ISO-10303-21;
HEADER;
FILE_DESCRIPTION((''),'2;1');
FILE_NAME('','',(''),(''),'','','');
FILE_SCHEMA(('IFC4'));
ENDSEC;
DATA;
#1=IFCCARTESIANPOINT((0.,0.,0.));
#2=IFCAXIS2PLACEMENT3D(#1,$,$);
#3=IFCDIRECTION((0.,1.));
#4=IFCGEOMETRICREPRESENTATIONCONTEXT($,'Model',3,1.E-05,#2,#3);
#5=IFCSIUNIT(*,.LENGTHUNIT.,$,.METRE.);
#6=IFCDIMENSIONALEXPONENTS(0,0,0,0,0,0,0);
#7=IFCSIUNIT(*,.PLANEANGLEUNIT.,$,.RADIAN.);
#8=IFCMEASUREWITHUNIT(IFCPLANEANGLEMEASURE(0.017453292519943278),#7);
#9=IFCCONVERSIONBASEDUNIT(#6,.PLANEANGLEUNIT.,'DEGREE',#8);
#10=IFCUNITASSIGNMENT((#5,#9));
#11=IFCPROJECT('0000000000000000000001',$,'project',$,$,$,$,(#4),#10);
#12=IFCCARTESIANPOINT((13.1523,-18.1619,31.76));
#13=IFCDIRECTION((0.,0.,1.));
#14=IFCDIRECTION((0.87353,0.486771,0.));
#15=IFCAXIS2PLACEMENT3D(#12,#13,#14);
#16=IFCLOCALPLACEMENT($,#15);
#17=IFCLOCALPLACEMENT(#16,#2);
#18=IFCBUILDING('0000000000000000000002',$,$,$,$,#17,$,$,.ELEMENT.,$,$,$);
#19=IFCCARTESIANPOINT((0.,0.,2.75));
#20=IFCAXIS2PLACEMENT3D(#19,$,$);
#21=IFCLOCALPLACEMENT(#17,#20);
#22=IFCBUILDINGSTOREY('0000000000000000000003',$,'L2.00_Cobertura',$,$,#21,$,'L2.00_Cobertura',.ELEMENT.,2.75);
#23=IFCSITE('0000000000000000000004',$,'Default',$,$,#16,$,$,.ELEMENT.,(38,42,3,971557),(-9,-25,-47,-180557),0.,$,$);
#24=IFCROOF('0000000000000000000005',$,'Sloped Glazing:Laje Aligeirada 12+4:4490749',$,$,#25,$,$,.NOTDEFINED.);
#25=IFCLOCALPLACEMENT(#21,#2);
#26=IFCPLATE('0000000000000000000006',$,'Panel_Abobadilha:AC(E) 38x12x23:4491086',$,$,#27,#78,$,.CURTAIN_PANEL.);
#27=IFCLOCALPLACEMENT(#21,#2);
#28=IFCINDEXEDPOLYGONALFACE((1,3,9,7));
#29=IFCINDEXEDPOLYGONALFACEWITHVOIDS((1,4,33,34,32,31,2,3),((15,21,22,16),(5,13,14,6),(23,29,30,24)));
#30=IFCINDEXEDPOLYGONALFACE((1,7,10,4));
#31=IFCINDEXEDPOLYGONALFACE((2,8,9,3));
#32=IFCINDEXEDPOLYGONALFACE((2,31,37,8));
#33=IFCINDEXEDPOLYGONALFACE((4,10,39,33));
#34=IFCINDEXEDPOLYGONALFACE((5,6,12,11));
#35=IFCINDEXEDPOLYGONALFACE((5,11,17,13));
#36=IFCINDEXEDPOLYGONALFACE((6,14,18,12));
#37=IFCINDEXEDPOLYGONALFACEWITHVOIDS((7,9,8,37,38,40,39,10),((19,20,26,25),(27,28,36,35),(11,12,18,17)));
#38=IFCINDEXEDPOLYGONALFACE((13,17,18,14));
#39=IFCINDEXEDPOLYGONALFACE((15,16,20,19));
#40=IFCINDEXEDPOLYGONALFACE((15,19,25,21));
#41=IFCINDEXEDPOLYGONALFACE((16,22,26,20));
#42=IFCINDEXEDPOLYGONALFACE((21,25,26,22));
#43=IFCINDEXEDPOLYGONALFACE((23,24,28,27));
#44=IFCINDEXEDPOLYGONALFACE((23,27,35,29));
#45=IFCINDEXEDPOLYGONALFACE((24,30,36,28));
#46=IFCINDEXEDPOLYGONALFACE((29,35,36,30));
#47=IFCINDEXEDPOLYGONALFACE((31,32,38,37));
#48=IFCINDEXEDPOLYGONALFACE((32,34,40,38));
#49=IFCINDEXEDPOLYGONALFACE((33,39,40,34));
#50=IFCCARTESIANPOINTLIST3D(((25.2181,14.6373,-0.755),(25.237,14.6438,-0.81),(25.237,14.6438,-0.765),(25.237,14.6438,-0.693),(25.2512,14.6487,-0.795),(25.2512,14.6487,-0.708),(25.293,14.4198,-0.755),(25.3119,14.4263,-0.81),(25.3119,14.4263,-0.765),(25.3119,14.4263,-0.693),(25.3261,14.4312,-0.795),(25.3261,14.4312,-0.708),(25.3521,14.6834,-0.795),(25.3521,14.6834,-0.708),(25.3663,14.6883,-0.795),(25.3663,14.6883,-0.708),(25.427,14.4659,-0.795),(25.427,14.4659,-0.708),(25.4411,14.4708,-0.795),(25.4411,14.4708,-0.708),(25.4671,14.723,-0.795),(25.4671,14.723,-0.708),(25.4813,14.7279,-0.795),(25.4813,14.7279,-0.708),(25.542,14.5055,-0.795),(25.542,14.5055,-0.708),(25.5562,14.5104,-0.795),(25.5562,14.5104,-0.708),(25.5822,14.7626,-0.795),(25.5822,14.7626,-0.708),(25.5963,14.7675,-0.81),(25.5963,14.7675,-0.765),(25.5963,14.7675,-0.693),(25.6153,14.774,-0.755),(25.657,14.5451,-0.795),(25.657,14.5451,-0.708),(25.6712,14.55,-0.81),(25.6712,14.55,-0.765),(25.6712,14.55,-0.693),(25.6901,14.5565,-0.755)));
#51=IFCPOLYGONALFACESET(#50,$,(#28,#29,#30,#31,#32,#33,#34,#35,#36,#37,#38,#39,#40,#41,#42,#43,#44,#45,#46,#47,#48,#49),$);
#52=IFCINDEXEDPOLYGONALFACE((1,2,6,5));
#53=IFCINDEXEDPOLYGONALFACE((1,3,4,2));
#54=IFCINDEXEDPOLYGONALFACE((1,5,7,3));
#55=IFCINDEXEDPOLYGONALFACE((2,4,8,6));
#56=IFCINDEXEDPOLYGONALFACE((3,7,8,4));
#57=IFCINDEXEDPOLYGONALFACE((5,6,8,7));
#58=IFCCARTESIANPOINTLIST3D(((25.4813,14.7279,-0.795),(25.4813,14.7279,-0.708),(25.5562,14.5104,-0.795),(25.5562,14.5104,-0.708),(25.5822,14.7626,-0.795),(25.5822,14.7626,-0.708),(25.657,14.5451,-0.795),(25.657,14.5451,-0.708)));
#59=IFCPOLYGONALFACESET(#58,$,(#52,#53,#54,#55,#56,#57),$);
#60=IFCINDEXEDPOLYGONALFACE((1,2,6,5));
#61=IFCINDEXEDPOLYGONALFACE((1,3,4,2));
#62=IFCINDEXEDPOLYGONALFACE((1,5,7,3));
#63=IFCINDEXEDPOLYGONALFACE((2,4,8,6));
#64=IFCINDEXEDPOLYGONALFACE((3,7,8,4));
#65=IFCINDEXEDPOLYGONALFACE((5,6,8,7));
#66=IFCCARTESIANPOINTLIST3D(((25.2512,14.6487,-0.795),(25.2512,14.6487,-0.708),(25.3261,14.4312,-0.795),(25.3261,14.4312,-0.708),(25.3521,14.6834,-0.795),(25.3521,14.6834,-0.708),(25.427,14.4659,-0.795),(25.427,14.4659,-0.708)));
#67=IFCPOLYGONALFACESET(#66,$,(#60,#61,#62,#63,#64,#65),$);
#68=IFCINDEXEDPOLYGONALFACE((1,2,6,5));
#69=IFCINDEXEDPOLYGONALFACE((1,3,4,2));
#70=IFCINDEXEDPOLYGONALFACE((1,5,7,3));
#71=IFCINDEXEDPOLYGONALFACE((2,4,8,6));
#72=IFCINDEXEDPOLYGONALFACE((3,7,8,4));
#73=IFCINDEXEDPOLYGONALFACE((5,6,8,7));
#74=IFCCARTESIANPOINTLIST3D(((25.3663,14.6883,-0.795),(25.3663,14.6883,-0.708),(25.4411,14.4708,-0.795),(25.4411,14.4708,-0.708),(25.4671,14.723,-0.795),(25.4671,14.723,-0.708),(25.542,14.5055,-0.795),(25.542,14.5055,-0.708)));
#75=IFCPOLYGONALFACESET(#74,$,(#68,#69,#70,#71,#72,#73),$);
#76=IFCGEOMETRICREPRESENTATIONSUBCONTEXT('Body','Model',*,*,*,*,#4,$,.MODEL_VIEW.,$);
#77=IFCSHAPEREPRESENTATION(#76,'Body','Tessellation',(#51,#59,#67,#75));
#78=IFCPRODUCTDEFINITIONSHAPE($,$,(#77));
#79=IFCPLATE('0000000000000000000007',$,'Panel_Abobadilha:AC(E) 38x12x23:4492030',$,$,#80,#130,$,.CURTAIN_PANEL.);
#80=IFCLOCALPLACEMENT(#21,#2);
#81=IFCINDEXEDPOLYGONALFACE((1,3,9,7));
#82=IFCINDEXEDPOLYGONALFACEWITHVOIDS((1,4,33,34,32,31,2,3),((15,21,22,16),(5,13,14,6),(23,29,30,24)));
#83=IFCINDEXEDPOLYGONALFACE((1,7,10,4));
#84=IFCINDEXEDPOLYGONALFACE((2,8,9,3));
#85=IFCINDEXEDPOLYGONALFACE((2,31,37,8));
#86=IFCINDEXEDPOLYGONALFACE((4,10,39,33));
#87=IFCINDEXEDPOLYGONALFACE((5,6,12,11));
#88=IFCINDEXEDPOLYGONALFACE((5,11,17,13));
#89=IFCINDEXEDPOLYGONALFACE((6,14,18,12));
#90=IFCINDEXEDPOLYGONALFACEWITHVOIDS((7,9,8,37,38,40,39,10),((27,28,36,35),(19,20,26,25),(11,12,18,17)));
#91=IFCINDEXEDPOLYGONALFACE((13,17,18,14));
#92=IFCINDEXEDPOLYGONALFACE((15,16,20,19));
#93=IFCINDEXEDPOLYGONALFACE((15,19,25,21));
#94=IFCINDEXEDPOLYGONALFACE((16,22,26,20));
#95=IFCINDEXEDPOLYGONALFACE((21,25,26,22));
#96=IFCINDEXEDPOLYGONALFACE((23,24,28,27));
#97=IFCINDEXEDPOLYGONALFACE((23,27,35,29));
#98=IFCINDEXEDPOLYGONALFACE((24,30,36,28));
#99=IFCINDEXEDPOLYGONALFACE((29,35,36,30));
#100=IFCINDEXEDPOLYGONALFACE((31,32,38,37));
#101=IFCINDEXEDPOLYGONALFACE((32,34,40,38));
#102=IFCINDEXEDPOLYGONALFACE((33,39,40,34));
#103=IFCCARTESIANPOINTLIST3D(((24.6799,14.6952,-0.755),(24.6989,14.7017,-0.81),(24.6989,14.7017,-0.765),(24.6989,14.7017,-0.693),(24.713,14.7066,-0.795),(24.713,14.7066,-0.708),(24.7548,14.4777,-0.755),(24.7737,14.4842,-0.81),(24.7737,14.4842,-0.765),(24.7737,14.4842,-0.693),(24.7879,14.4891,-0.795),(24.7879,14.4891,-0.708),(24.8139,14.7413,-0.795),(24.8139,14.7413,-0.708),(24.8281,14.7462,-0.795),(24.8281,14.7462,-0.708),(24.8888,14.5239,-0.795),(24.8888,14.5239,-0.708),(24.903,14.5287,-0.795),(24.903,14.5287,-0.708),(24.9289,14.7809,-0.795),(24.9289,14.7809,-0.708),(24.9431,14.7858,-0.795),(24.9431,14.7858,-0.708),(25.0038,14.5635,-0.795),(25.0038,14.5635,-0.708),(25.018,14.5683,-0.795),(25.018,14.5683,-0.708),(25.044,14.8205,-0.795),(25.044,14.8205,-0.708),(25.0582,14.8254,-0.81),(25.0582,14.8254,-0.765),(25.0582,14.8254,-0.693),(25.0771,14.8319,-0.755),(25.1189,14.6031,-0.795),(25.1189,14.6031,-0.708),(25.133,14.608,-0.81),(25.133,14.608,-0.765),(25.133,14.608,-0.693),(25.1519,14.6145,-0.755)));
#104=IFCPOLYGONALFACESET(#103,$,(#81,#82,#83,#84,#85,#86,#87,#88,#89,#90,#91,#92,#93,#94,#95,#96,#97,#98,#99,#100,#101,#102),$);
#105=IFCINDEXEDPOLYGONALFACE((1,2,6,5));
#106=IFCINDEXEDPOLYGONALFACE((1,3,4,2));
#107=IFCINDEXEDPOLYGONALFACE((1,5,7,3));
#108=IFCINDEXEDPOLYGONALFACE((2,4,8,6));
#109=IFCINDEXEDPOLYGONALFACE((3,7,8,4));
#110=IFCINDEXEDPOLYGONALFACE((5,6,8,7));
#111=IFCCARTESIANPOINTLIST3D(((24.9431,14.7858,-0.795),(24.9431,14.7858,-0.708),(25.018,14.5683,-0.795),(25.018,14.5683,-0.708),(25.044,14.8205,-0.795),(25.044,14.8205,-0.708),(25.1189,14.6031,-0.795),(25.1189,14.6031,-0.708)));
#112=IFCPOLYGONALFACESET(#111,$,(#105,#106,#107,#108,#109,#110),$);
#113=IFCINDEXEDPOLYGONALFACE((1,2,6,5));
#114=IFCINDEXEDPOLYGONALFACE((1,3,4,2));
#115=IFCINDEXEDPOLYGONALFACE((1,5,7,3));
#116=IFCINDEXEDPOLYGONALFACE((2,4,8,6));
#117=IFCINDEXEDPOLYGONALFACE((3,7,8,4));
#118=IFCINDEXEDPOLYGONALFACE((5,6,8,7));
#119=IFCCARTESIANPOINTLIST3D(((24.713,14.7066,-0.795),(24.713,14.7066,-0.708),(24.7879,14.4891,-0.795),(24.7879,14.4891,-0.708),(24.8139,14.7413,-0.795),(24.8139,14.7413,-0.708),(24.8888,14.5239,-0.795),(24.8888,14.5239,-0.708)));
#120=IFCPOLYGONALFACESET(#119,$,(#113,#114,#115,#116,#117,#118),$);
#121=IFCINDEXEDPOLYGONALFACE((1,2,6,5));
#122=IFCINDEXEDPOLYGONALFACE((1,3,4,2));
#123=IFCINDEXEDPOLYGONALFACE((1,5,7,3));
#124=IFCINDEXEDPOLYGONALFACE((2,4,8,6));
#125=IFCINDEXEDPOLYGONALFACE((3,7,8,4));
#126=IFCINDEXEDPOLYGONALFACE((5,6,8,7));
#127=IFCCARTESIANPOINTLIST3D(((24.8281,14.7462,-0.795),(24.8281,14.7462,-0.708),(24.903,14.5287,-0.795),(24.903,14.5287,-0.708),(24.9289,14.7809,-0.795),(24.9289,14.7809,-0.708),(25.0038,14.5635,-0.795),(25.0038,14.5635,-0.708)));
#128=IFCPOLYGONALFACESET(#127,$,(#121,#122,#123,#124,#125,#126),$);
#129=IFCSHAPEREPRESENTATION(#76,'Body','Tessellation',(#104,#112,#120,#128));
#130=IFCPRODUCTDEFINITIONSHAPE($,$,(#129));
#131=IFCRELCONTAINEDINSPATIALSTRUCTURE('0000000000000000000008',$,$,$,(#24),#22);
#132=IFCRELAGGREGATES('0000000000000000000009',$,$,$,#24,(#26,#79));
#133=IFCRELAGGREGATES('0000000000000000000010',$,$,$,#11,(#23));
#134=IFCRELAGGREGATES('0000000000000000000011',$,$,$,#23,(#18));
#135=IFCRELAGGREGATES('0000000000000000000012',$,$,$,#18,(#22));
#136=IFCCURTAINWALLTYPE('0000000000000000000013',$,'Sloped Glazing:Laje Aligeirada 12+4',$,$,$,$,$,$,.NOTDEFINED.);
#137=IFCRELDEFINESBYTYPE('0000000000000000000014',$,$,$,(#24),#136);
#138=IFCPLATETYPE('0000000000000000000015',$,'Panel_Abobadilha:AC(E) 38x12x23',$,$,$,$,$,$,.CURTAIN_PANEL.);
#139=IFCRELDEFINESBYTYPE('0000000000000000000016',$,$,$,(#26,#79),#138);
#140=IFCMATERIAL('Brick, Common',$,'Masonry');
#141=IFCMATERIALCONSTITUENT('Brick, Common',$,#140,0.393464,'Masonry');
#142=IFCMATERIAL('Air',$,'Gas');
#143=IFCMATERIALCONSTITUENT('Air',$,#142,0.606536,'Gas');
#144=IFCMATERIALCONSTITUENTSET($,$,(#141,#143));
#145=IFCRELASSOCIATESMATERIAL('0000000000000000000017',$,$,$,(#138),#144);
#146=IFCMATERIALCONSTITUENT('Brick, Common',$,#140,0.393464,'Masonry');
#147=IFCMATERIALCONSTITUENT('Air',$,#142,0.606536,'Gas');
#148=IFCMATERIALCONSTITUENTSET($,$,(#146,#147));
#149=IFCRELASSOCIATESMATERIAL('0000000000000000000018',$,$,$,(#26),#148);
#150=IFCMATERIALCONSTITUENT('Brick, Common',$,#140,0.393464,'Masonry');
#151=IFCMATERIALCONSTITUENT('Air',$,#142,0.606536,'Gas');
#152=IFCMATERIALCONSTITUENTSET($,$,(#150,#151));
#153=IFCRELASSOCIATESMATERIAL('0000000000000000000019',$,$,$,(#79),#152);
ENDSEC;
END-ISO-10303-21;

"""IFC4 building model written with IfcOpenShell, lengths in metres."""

from ifc_helpers import new_model, entity, si_unit, converted_unit, direction, frame, origin, place, context, subcontext, project, spatial, indexed_curve, outline, extrude, source, transform, mapped, material, constituent, constituent_set, type_object, type_shapes, element, aggregate, save


model = new_model("IFC4")

# Units and contexts
model_context = context("Model", 3, precision=1e-05, world=origin(), true_north=direction((0.0, 1.0)))
body_context = subcontext(model_context, "Body", "Model", "MODEL_VIEW")
ifc_project = project(units=[si_unit("LENGTHUNIT", "METRE"), converted_unit("PLANEANGLEUNIT", "DEGREE", entity("IfcPlaneAngleMeasure", 0.017453292519943278), si_unit("PLANEANGLEUNIT", "RADIAN"), dimensions=[0, 0, 0, 0, 0, 0, 0])], contexts=[model_context])

# Site, building, storey
site_placement = place(None, frame((13.1523, -18.1619, 31.76), z_axis=(0.0, 0.0, 1.0), x_axis=(0.87353, 0.486771, 0.0)))
site = spatial("IfcSite", under=ifc_project, at=site_placement, Name="Default", CompositionType="ELEMENT", RefLatitude=(38, 42, 3, 971557), RefLongitude=(-9, -25, -47, -180557), RefElevation=0.0)
building_placement = place(site_placement, origin())
building = spatial("IfcBuilding", under=site, at=building_placement, CompositionType="ELEMENT")
storey_placement = place(building_placement, frame((0.0, 0.0, 2.75)))
storey = spatial("IfcBuildingStorey", under=building, at=storey_placement, Name="L2.00_Cobertura", LongName="L2.00_Cobertura", CompositionType="ELEMENT", Elevation=2.75)

# Roof, plates
curtain_wall_type = type_object("IfcCurtainWallType", Name="Sloped Glazing:Laje Aligeirada 12+4", PredefinedType="NOTDEFINED")
roof_placement = place(storey_placement, frame((0.0, 0.0, -2.75)))
roof = element("IfcRoof", 1, at=roof_placement, inside=storey, type_object=curtain_wall_type, Name="Sloped Glazing:Laje Aligeirada 12+4:4490749", PredefinedType="NOTDEFINED")
ifc_material_1 = material(Name="Brick, Common", Category="Masonry")
ifc_material_2 = material(Name="Air", Category="Gas")
ifc_constituent_1 = constituent(ifc_material_1, Name="Brick, Common", Category="Masonry", fraction=0.393464)
ifc_constituent_2 = constituent(ifc_material_2, Name="Air", Category="Gas", fraction=0.606536)
ifc_constituent_set_1 = constituent_set(constituents=[ifc_constituent_1, ifc_constituent_2])
plate_type = type_object("IfcPlateType", Name="Panel_Abobadilha:AC(E) 38x12x23", PredefinedType="CURTAIN_PANEL", material=ifc_constituent_set_1)
shared_shape_1 = source(origin(), body_context, "Body", "SweptSolid", [
    extrude(outline(indexed_curve([(-0.19, -0.0543), (0.19, -0.0543), (0.19, -0.0093), (0.21, 0.0007), (0.19, 0.0628), (-0.19, 0.0628), (-0.21, 0.0007), (-0.19, -0.0093), (-0.19, -0.0543)], self_intersect=False), holes=[indexed_curve([(-0.0683, 0.0477), (-0.0683, -0.0393), (-0.175, -0.0393), (-0.175, 0.0477), (-0.0683, 0.0477)], self_intersect=False), indexed_curve([(0.0533, 0.0477), (0.0533, -0.0393), (-0.0533, -0.0393), (-0.0533, 0.0477), (0.0533, 0.0477)], self_intersect=False), indexed_curve([(0.175, 0.0477), (0.175, -0.0393), (0.0683, -0.0393), (0.0683, 0.0477), (0.175, 0.0477)], self_intersect=False)]), frame((0.0, 0.0543, 0.0)), (0.0, 0.0, 1.0), 0.23),
    extrude(outline(indexed_curve([(-0.0533, -0.0435), (0.0533, -0.0435), (0.0533, 0.0435), (-0.0533, 0.0435), (-0.0533, -0.0435)], self_intersect=False)), frame((0.1217, 0.0585, 0.0), z_axis=(0.0, 0.0, 1.0), x_axis=(-1.0, 0.0, 0.0)), (0.0, 0.0, 1.0), 0.23),
    extrude(outline(indexed_curve([(-0.0533, -0.0435), (0.0533, -0.0435), (0.0533, 0.0435), (-0.0533, 0.0435), (-0.0533, -0.0435)], self_intersect=False)), frame((-0.1217, 0.0585, 0.0), z_axis=(0.0, 0.0, 1.0), x_axis=(-1.0, 0.0, 0.0)), (0.0, 0.0, 1.0), 0.23),
    extrude(outline(indexed_curve([(-0.0533, -0.0435), (0.0533, -0.0435), (0.0533, 0.0435), (-0.0533, 0.0435), (-0.0533, -0.0435)], self_intersect=False)), frame((0.0, 0.0585, 0.0), z_axis=(0.0, 0.0, 1.0), x_axis=(-1.0, 0.0, 0.0)), (0.0, 0.0, 1.0), 0.23),
])
type_shapes(plate_type, [shared_shape_1])
ifc_constituent_3 = constituent(ifc_material_1, Name="Brick, Common", Category="Masonry", fraction=0.393464)
ifc_constituent_4 = constituent(ifc_material_2, Name="Air", Category="Gas", fraction=0.606536)
ifc_constituent_set_2 = constituent_set(constituents=[ifc_constituent_3, ifc_constituent_4])
plate_1_placement = place(roof_placement, frame((25.4167, 14.7056, 1.94), z_axis=(0.325568, -0.945519, 0.0), x_axis=(0.945519, 0.325568, 0.0)))
plate_1 = element("IfcPlate", 2, at=plate_1_placement, type_object=plate_type, material=ifc_constituent_set_2, Name="Panel_Abobadilha:AC(E) 38x12x23:4491086", PredefinedType="CURTAIN_PANEL", context=body_context, shape_type="MappedRepresentation", body=[
    mapped(shared_shape_1, transform((0.0, 0.0, 0.0), scale=1.0)),
])
ifc_constituent_5 = constituent(ifc_material_1, Name="Brick, Common", Category="Masonry", fraction=0.393464)
ifc_constituent_6 = constituent(ifc_material_2, Name="Air", Category="Gas", fraction=0.606536)
ifc_constituent_set_3 = constituent_set(constituents=[ifc_constituent_5, ifc_constituent_6])
plate_2_placement = place(roof_placement, frame((24.8785, 14.7636, 1.94), z_axis=(0.325568, -0.945519, 0.0), x_axis=(0.945519, 0.325568, 0.0)))
plate_2 = element("IfcPlate", 3, at=plate_2_placement, type_object=plate_type, material=ifc_constituent_set_3, Name="Panel_Abobadilha:AC(E) 38x12x23:4492030", PredefinedType="CURTAIN_PANEL", context=body_context, shape_type="MappedRepresentation", body=[
    mapped(shared_shape_1, transform((0.0, 0.0, 0.0), scale=1.0)),
])
aggregate(roof, [plate_1, plate_2])

save(model, "model.ifc")
